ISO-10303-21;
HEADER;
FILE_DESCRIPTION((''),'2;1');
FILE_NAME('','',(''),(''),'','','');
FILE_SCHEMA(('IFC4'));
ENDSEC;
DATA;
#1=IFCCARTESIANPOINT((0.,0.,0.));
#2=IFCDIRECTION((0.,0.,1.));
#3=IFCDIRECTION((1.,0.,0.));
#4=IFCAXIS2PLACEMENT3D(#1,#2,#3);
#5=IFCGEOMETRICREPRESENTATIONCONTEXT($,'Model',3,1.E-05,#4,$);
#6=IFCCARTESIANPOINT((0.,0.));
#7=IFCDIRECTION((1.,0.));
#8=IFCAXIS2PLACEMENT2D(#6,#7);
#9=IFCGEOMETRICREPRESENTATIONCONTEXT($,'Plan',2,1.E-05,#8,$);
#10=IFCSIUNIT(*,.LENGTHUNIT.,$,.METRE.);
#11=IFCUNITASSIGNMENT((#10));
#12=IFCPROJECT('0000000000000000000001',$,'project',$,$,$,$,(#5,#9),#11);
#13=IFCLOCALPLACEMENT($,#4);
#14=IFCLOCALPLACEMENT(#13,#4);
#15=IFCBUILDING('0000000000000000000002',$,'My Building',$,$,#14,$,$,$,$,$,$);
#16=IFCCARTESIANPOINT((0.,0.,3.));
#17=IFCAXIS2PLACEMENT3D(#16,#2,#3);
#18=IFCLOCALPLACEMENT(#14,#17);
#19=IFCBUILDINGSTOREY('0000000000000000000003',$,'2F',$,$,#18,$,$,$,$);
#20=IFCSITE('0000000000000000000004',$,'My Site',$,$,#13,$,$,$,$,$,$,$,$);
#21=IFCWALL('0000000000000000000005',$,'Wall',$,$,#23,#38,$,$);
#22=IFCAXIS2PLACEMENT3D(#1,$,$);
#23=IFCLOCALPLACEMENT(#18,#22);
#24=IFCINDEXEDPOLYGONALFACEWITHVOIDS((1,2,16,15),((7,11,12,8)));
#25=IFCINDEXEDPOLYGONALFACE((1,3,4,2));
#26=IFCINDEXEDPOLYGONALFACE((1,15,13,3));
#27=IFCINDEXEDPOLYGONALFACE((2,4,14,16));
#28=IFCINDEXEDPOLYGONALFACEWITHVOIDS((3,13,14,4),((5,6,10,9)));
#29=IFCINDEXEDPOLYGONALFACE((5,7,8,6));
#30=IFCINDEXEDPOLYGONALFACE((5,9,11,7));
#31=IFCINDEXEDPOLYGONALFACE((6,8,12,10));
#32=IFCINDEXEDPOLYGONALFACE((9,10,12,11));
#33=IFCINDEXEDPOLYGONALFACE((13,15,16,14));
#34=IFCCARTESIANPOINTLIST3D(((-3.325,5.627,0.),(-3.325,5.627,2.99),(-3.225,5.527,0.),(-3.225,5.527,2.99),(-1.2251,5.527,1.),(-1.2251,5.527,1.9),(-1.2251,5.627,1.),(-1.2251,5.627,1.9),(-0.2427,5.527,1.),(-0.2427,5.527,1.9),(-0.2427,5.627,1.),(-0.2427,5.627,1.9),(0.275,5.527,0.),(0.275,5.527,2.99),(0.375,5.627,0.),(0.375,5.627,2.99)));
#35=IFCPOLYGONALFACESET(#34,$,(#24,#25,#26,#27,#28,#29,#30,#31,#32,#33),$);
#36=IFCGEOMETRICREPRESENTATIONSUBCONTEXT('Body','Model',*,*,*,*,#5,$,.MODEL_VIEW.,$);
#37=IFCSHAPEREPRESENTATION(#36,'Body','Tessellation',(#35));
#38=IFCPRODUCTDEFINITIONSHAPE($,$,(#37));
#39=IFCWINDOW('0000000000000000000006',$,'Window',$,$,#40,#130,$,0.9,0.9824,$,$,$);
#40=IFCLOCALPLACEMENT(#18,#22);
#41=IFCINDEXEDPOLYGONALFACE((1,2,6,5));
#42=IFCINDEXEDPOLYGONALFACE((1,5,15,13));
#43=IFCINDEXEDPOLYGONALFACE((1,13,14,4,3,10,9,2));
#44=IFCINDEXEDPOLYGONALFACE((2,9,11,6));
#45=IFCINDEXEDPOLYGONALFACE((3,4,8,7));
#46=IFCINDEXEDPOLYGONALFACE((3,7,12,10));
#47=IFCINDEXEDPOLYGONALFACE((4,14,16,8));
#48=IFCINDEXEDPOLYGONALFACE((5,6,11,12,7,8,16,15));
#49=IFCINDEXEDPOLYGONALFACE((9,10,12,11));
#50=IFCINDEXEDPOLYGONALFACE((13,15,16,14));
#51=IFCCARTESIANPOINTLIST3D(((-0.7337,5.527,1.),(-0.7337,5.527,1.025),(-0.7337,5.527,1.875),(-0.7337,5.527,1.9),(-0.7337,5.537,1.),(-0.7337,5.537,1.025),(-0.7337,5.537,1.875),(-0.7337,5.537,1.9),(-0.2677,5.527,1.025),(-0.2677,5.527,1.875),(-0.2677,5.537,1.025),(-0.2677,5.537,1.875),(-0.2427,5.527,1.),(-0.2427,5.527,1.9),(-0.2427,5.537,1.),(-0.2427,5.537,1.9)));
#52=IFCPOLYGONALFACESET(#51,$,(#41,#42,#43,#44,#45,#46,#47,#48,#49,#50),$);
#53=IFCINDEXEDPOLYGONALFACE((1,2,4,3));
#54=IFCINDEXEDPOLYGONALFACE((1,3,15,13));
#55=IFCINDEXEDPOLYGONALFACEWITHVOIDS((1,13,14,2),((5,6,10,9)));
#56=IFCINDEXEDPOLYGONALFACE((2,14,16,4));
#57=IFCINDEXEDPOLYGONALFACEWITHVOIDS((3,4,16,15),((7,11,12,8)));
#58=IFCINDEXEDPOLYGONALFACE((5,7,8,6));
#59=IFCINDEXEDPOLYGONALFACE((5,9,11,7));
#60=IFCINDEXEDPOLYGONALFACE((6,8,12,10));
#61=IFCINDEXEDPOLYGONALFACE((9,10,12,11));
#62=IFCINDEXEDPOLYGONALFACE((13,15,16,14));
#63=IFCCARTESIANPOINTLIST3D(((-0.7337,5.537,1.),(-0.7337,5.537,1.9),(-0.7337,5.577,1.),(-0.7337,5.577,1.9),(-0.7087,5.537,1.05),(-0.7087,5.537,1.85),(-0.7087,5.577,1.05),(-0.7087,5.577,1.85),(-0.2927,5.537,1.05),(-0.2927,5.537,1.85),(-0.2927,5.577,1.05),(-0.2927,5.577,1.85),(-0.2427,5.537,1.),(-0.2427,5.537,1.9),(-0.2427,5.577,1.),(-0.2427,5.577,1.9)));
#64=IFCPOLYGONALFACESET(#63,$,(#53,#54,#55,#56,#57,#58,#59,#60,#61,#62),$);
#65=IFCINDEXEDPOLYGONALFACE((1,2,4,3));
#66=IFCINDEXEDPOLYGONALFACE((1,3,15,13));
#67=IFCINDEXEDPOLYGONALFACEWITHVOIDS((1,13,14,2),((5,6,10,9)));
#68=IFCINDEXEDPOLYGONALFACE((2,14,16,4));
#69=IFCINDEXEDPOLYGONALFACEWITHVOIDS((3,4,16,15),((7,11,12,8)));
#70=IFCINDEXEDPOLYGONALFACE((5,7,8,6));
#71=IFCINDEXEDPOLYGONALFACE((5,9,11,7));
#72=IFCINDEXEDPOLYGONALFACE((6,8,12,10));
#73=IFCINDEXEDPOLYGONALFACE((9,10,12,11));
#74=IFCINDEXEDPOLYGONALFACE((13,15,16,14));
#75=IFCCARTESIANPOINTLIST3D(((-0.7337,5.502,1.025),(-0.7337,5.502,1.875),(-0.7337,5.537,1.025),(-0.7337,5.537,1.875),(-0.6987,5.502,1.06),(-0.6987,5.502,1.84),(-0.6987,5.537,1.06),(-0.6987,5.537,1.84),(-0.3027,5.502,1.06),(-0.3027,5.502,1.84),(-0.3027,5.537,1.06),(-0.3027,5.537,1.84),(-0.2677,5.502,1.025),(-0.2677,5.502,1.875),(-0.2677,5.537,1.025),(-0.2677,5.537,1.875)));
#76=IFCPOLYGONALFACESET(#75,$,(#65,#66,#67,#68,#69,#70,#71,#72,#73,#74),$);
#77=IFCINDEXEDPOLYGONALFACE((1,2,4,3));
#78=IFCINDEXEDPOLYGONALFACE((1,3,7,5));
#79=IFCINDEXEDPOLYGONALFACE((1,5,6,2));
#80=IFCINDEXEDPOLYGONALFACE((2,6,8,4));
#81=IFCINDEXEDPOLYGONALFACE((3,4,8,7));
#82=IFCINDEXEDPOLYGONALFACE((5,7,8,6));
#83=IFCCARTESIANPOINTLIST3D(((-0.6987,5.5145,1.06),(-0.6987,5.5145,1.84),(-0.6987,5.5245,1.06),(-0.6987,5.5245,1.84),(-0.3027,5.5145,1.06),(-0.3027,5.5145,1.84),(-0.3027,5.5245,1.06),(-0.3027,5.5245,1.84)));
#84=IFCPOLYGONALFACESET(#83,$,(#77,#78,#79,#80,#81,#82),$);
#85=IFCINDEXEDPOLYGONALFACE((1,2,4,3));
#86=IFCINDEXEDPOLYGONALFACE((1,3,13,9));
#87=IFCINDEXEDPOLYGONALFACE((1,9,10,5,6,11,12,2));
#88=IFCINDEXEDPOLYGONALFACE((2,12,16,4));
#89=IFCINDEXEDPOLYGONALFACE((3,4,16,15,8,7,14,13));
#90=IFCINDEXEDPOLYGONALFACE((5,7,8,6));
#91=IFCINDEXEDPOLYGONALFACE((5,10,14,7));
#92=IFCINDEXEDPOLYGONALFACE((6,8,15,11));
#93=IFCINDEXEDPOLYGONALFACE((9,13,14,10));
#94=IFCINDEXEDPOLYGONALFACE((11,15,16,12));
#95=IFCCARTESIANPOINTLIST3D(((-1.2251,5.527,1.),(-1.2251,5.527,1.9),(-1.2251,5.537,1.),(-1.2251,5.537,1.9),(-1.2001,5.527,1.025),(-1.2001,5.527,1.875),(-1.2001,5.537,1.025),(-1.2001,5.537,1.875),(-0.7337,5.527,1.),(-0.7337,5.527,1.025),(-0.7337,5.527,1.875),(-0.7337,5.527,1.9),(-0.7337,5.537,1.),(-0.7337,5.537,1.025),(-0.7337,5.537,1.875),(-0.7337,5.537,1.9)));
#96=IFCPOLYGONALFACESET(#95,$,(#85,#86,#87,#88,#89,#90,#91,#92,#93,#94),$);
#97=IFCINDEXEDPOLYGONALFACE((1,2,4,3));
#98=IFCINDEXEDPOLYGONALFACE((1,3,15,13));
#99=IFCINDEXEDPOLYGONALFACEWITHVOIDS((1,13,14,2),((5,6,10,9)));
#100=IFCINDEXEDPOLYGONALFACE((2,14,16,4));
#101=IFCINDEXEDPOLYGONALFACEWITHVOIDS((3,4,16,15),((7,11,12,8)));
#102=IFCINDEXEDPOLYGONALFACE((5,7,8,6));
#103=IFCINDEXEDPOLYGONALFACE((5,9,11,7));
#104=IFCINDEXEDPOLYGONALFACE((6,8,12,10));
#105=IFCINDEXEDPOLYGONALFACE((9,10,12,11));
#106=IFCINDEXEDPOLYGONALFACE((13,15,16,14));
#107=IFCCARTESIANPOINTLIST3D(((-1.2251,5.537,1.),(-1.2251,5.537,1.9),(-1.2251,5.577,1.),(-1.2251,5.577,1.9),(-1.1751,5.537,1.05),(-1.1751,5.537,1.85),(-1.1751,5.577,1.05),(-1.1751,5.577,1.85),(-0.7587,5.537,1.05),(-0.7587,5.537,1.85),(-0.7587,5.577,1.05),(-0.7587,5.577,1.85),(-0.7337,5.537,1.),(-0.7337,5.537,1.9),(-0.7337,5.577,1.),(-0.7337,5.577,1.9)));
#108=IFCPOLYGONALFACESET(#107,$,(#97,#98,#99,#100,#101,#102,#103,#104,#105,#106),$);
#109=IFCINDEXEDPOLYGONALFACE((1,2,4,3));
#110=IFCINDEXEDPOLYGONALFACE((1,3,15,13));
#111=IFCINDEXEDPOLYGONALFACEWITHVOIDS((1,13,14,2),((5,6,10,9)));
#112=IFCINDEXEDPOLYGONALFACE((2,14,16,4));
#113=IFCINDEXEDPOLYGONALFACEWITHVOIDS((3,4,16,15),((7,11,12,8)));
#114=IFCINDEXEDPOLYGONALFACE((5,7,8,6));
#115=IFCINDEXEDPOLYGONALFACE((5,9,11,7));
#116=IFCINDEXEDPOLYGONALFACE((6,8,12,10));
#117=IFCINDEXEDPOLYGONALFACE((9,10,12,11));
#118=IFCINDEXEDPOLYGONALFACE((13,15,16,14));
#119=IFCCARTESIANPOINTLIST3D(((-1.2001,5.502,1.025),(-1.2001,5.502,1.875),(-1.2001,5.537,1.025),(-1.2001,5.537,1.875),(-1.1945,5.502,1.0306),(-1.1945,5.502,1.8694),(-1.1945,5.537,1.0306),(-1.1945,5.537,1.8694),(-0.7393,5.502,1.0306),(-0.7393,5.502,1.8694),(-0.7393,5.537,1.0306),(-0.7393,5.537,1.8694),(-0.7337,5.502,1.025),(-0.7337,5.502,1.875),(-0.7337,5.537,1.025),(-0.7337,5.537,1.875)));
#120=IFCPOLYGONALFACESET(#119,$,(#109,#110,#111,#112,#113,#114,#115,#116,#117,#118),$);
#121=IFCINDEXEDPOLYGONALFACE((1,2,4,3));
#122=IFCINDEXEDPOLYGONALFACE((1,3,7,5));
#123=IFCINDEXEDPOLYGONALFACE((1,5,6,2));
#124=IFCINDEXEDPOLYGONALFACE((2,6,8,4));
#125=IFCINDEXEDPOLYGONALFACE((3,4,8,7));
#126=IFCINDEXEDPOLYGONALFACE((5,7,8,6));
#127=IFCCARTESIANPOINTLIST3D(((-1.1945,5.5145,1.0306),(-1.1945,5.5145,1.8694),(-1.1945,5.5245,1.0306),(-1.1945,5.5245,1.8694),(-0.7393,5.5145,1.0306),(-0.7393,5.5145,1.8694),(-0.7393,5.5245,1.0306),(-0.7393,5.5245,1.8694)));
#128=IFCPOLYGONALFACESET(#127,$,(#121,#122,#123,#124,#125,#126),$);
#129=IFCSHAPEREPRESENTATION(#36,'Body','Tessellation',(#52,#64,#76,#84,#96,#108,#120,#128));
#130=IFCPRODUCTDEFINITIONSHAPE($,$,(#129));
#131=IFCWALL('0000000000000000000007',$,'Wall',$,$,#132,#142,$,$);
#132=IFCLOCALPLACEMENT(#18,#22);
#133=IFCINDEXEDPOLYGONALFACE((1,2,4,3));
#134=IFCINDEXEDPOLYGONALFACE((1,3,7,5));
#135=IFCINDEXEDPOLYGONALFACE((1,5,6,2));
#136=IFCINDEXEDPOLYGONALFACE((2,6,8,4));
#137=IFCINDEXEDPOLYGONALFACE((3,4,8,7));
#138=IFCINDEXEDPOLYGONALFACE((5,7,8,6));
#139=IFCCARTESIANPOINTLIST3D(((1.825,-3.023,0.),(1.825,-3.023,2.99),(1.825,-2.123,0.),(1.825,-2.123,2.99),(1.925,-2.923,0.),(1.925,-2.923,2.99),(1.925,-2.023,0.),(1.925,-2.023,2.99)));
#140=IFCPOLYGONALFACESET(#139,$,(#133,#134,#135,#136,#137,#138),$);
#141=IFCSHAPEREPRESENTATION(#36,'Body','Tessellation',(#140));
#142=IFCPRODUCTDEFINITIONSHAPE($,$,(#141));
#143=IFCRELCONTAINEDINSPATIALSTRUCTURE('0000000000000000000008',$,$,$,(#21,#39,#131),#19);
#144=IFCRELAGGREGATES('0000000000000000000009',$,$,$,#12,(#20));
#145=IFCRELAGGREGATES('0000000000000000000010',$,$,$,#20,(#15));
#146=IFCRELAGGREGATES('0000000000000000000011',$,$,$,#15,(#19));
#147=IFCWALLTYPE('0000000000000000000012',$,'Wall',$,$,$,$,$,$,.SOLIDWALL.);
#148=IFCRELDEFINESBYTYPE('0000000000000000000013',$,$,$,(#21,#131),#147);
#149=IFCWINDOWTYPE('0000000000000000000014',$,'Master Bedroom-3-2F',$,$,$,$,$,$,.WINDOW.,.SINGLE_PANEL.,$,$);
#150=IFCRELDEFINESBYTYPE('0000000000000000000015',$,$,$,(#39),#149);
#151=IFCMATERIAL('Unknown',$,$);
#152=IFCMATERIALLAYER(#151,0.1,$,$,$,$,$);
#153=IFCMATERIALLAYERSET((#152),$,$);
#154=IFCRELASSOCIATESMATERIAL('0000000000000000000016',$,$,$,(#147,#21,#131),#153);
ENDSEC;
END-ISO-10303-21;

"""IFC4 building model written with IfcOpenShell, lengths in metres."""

from ifc_helpers import new_model, entity, si_unit, frame, origin_with_axes, origin_2d_with_axis, place, context, subcontext, project, spatial, line, indexed_curve, outline, extrude, shape, source, transform, mapped, material, layer, layer_set, layer_usage, type_object, type_shapes, element, fill, save


model = new_model("IFC4")

# Units and contexts
model_context = context("Model", 3, precision=1e-05, world=origin_with_axes())
plan_context = context("Plan", 2, precision=1e-05, world=origin_2d_with_axis())
body_context_1 = subcontext(model_context, "Body", "Model", "MODEL_VIEW")
body_context_2 = subcontext(plan_context, "Body", "Plan", "PLAN_VIEW")
ifc_project = project(units=[si_unit("LENGTHUNIT", "METRE")], contexts=[model_context, plan_context])

# Site, building, storey
site_placement = place(None, origin_with_axes())
site = spatial("IfcSite", under=ifc_project, at=site_placement, Name="My Site")
building_placement = place(site_placement, origin_with_axes())
building = spatial("IfcBuilding", under=site, at=building_placement, Name="My Building")
storey_placement = place(building_placement, frame((0.0, 0.0, 3.0), z_axis=(0.0, 0.0, 1.0), x_axis=(1.0, 0.0, 0.0)))
storey = spatial("IfcBuildingStorey", under=building, at=storey_placement, Name="2F")

# Shared definitions
ifc_material = material(Name="Unknown")

# Shared definitions
ifc_layer_1 = layer(ifc_material, 0.1)
ifc_layer_set_1 = layer_set([ifc_layer_1])
wall_type = type_object("IfcWallType", Name="Wall", PredefinedType="SOLIDWALL", material=ifc_layer_set_1)

# Wall, opening, window
ifc_layer_usage_1 = layer_usage(ifc_layer_set_1, "AXIS2", "POSITIVE", 0.0)
wall_1_placement = place(storey_placement, frame((0.275, 5.627, 0.0), z_axis=(0.0, 0.0, 1.0), x_axis=(-1.0, 0.0, 0.0)))
wall_1 = element("IfcWall", 1, at=wall_1_placement, inside=storey, type_object=wall_type, material=ifc_layer_usage_1, Name="Wall", context=body_context_1, shape_type="SweptSolid", body=[
    extrude(outline(indexed_curve([(-0.1, 0.0), (0.0, 0.1), (3.5, 0.1), (3.6, 0.0)], segments=[line(1, 2, 3, 4, 1)])), origin_with_axes(), (0.0, 0.0, 1.0), 2.99),
])
shared_shape_1 = source(origin_with_axes(), body_context_1, "Body", "SweptSolid", [
    extrude(outline(indexed_curve([(0.0, 0.0), (0.9824, 0.0), (0.9824, 0.9), (0.0, 0.9)], segments=[line(1, 2, 3, 4, 1)])), frame((0.0, -0.6, 0.0), z_axis=(0.0, -1.0, 0.0), x_axis=(1.0, 0.0, 0.0)), (0.0, 0.0, -1.0), 1.2),
])
opening_1_placement = place(wall_1_placement, frame((0.5177, 0.0, 1.0), z_axis=(0.0, 0.0, 1.0), x_axis=(1.0, 0.0, 0.0)))
opening_1 = element("IfcOpeningElement", 2, at=opening_1_placement, cuts=wall_1, PredefinedType="OPENING", context=body_context_1, shape_type="MappedRepresentation", body=[
    mapped(shared_shape_1, transform((0.0, 0.0, 0.0), x_axis=(1.0, 0.0, 0.0), y_axis=(0.0, 1.0, 0.0), z_axis=(0.0, 0.0, 1.0), scale=1.0)),
])
window_type_1 = type_object("IfcWindowType", Name="Master Bedroom-3-2F", PartitioningType="SINGLE_PANEL", PredefinedType="WINDOW")
shared_shape_2 = source(origin_with_axes(), body_context_1, "Body", "SweptSolid", [
    extrude(outline(indexed_curve([(0.4911, 0.0), (0.0, 0.0), (0.0, 0.9), (0.4911, 0.9), (0.4911, 0.875), (0.025, 0.875), (0.025, 0.025), (0.4911, 0.025)], segments=[line(1, 2, 3, 4, 5, 6, 7, 8, 1)])), frame((0.0, 0.09, 0.0), z_axis=(0.0, -1.0, 0.0), x_axis=(1.0, 0.0, 0.0)), (0.0, 0.0, -1.0), 0.01),
    extrude(outline(indexed_curve([(0.0, 0.0), (0.4911, 0.0), (0.4911, 0.9), (0.0, 0.9)], segments=[line(1, 2, 3, 4, 1)]), holes=[indexed_curve([(0.05, 0.05), (0.4661, 0.05), (0.4661, 0.85), (0.05, 0.85)], segments=[line(1, 2, 3, 4, 1)])]), frame((0.0, 0.05, 0.0), z_axis=(0.0, -1.0, 0.0), x_axis=(1.0, 0.0, 0.0)), (0.0, 0.0, -1.0), 0.04),
    extrude(outline(indexed_curve([(0.0, 0.0), (0.4661, 0.0), (0.4661, 0.85), (0.0, 0.85)], segments=[line(1, 2, 3, 4, 1)]), holes=[indexed_curve([(0.035, 0.035), (0.4311, 0.035), (0.4311, 0.815), (0.035, 0.815)], segments=[line(1, 2, 3, 4, 1)])]), frame((0.025, 0.09, 0.025), z_axis=(0.0, -1.0, 0.0), x_axis=(1.0, 0.0, 0.0)), (0.0, 0.0, -1.0), 0.035),
    extrude(outline(indexed_curve([(0.035, 0.035), (0.4311, 0.035), (0.4311, 0.815), (0.035, 0.815)], segments=[line(1, 2, 3, 4, 1)])), frame((0.025, 0.1025, 0.025), z_axis=(0.0, -1.0, 0.0), x_axis=(1.0, 0.0, 0.0)), (0.0, 0.0, -1.0), 0.01),
    extrude(outline(indexed_curve([(0.0, 0.9), (0.4913, 0.9), (0.4913, 0.0), (0.0, 0.0), (0.0, 0.025), (0.4663, 0.025), (0.4663, 0.875), (0.0, 0.875)], segments=[line(1, 2, 3, 4, 5, 6, 7, 8, 1)])), frame((0.4911, 0.09, 0.0), z_axis=(0.0, -1.0, 0.0), x_axis=(1.0, 0.0, 0.0)), (0.0, 0.0, -1.0), 0.01),
    extrude(outline(indexed_curve([(0.0, 0.0), (0.4913, 0.0), (0.4913, 0.9), (0.0, 0.9)], segments=[line(1, 2, 3, 4, 1)]), holes=[indexed_curve([(0.025, 0.05), (0.4413, 0.05), (0.4413, 0.85), (0.025, 0.85)], segments=[line(1, 2, 3, 4, 1)])]), frame((0.4911, 0.05, 0.0), z_axis=(0.0, -1.0, 0.0), x_axis=(1.0, 0.0, 0.0)), (0.0, 0.0, -1.0), 0.04),
    extrude(outline(indexed_curve([(0.0, 0.0), (0.4663, 0.0), (0.4663, 0.85), (0.0, 0.85)], segments=[line(1, 2, 3, 4, 1)]), holes=[indexed_curve([(0.0056, 0.0056), (0.4608, 0.0056), (0.4608, 0.8444), (0.0056, 0.8444)], segments=[line(1, 2, 3, 4, 1)])]), frame((0.4911, 0.09, 0.025), z_axis=(0.0, -1.0, 0.0), x_axis=(1.0, 0.0, 0.0)), (0.0, 0.0, -1.0), 0.035),
    extrude(outline(indexed_curve([(0.0056, 0.0056), (0.4608, 0.0056), (0.4608, 0.8444), (0.0056, 0.8444)], segments=[line(1, 2, 3, 4, 1)])), frame((0.4911, 0.1025, 0.025), z_axis=(0.0, -1.0, 0.0), x_axis=(1.0, 0.0, 0.0)), (0.0, 0.0, -1.0), 0.01),
])
shared_shape_3 = source(origin_with_axes(), body_context_2, "Body", "Curve2D", [
    entity("IfcIndexedPolyCurve", entity("IfcCartesianPointList2D", [[0.05, 0.05], [0.4661, 0.05]])),
    entity("IfcIndexedPolyCurve", entity("IfcCartesianPointList2D", [[0.0, 0.1], [0.025, 0.1], [0.025, 0.09], [0.05, 0.09], [0.05, 0.05], [0.0, 0.05]]), [entity("IfcLineIndex", [1, 2, 3, 4, 5, 6, 1])]),
    entity("IfcIndexedPolyCurve", entity("IfcCartesianPointList2D", [[0.4911, 0.1], [0.4911, 0.1], [0.4911, 0.09], [0.4661, 0.09], [0.4661, 0.05], [0.4911, 0.05]])),
    entity("IfcIndexedPolyCurve", entity("IfcCartesianPointList2D", [[0.025, 0.09], [0.06, 0.09], [0.06, 0.125], [0.025, 0.125]]), [entity("IfcLineIndex", [1, 2, 3, 4, 1])]),
    entity("IfcIndexedPolyCurve", entity("IfcCartesianPointList2D", [[0.4911, 0.09], [0.4561, 0.09], [0.4561, 0.125], [0.4911, 0.125]]), [entity("IfcLineIndex", [1, 2, 3, 4, 1])]),
    entity("IfcIndexedPolyCurve", entity("IfcCartesianPointList2D", [[0.06, 0.09], [0.4561, 0.09]])),
    entity("IfcIndexedPolyCurve", entity("IfcCartesianPointList2D", [[0.06, 0.125], [0.4561, 0.125]])),
    entity("IfcIndexedPolyCurve", entity("IfcCartesianPointList2D", [[0.06, 0.1075], [0.4561, 0.1075]])),
    entity("IfcIndexedPolyCurve", entity("IfcCartesianPointList2D", [[0.5161, 0.05], [0.9324, 0.05]])),
    entity("IfcIndexedPolyCurve", entity("IfcCartesianPointList2D", [[0.4911, 0.1], [0.4911, 0.1], [0.4911, 0.09], [0.5161, 0.09], [0.5161, 0.05], [0.4911, 0.05]])),
    entity("IfcIndexedPolyCurve", entity("IfcCartesianPointList2D", [[0.9824, 0.1], [0.9574, 0.1], [0.9574, 0.09], [0.9324, 0.09], [0.9324, 0.05], [0.9824, 0.05]]), [entity("IfcLineIndex", [1, 2, 3, 4, 5, 6, 1])]),
    entity("IfcIndexedPolyCurve", entity("IfcCartesianPointList2D", [[0.4911, 0.09], [0.4966, 0.09], [0.4966, 0.125], [0.4911, 0.125]]), [entity("IfcLineIndex", [1, 2, 3, 4, 1])]),
    entity("IfcIndexedPolyCurve", entity("IfcCartesianPointList2D", [[0.9574, 0.09], [0.9519, 0.09], [0.9519, 0.125], [0.9574, 0.125]]), [entity("IfcLineIndex", [1, 2, 3, 4, 1])]),
    entity("IfcIndexedPolyCurve", entity("IfcCartesianPointList2D", [[0.4966, 0.09], [0.9519, 0.09]])),
    entity("IfcIndexedPolyCurve", entity("IfcCartesianPointList2D", [[0.4966, 0.125], [0.9519, 0.125]])),
    entity("IfcIndexedPolyCurve", entity("IfcCartesianPointList2D", [[0.4966, 0.1075], [0.9519, 0.1075]])),
])
type_shapes(window_type_1, [shared_shape_2, shared_shape_3])
window_1_placement = place(opening_1_placement, frame((0.0, 0.0, 0.0), z_axis=(0.0, 0.0, 1.0), x_axis=(1.0, 0.0, 0.0)))
window_1 = element("IfcWindow", 3, at=window_1_placement, inside=storey, type_object=window_type_1, Name="Window", OverallHeight=0.9, OverallWidth=0.9824, shapes=[
    shape(body_context_1, "Body", "MappedRepresentation", [mapped(shared_shape_2, transform((0.0, 0.0, 0.0), x_axis=(1.0, 0.0, 0.0), y_axis=(0.0, 1.0, 0.0), z_axis=(0.0, 0.0, 1.0), scale=1.0))]),
    shape(body_context_2, "Body", "MappedRepresentation", [mapped(shared_shape_3, transform((0.0, 0.0, 0.0), x_axis=(1.0, 0.0, 0.0), y_axis=(0.0, 1.0, 0.0), z_axis=(0.0, 0.0, 1.0), scale=1.0))]),
])
fill(opening_1, window_1)

# Wall
ifc_layer_usage_2 = layer_usage(ifc_layer_set_1, "AXIS2", "POSITIVE", 0.0)
wall_2_placement = place(storey_placement, frame((1.825, -2.123, 0.0), z_axis=(0.0, 0.0, 1.0), x_axis=(0.0, -1.0, 0.0)))
element("IfcWall", 4, at=wall_2_placement, inside=storey, type_object=wall_type, material=ifc_layer_usage_2, Name="Wall", context=body_context_1, shape_type="SweptSolid", body=[
    extrude(outline(indexed_curve([(0.0, 0.0), (-0.1, 0.1), (0.8, 0.1), (0.9, 0.0)], segments=[line(1, 2, 3, 4, 1)])), origin_with_axes(), (0.0, 0.0, 1.0), 2.99),
])

save(model, "model.ifc")
